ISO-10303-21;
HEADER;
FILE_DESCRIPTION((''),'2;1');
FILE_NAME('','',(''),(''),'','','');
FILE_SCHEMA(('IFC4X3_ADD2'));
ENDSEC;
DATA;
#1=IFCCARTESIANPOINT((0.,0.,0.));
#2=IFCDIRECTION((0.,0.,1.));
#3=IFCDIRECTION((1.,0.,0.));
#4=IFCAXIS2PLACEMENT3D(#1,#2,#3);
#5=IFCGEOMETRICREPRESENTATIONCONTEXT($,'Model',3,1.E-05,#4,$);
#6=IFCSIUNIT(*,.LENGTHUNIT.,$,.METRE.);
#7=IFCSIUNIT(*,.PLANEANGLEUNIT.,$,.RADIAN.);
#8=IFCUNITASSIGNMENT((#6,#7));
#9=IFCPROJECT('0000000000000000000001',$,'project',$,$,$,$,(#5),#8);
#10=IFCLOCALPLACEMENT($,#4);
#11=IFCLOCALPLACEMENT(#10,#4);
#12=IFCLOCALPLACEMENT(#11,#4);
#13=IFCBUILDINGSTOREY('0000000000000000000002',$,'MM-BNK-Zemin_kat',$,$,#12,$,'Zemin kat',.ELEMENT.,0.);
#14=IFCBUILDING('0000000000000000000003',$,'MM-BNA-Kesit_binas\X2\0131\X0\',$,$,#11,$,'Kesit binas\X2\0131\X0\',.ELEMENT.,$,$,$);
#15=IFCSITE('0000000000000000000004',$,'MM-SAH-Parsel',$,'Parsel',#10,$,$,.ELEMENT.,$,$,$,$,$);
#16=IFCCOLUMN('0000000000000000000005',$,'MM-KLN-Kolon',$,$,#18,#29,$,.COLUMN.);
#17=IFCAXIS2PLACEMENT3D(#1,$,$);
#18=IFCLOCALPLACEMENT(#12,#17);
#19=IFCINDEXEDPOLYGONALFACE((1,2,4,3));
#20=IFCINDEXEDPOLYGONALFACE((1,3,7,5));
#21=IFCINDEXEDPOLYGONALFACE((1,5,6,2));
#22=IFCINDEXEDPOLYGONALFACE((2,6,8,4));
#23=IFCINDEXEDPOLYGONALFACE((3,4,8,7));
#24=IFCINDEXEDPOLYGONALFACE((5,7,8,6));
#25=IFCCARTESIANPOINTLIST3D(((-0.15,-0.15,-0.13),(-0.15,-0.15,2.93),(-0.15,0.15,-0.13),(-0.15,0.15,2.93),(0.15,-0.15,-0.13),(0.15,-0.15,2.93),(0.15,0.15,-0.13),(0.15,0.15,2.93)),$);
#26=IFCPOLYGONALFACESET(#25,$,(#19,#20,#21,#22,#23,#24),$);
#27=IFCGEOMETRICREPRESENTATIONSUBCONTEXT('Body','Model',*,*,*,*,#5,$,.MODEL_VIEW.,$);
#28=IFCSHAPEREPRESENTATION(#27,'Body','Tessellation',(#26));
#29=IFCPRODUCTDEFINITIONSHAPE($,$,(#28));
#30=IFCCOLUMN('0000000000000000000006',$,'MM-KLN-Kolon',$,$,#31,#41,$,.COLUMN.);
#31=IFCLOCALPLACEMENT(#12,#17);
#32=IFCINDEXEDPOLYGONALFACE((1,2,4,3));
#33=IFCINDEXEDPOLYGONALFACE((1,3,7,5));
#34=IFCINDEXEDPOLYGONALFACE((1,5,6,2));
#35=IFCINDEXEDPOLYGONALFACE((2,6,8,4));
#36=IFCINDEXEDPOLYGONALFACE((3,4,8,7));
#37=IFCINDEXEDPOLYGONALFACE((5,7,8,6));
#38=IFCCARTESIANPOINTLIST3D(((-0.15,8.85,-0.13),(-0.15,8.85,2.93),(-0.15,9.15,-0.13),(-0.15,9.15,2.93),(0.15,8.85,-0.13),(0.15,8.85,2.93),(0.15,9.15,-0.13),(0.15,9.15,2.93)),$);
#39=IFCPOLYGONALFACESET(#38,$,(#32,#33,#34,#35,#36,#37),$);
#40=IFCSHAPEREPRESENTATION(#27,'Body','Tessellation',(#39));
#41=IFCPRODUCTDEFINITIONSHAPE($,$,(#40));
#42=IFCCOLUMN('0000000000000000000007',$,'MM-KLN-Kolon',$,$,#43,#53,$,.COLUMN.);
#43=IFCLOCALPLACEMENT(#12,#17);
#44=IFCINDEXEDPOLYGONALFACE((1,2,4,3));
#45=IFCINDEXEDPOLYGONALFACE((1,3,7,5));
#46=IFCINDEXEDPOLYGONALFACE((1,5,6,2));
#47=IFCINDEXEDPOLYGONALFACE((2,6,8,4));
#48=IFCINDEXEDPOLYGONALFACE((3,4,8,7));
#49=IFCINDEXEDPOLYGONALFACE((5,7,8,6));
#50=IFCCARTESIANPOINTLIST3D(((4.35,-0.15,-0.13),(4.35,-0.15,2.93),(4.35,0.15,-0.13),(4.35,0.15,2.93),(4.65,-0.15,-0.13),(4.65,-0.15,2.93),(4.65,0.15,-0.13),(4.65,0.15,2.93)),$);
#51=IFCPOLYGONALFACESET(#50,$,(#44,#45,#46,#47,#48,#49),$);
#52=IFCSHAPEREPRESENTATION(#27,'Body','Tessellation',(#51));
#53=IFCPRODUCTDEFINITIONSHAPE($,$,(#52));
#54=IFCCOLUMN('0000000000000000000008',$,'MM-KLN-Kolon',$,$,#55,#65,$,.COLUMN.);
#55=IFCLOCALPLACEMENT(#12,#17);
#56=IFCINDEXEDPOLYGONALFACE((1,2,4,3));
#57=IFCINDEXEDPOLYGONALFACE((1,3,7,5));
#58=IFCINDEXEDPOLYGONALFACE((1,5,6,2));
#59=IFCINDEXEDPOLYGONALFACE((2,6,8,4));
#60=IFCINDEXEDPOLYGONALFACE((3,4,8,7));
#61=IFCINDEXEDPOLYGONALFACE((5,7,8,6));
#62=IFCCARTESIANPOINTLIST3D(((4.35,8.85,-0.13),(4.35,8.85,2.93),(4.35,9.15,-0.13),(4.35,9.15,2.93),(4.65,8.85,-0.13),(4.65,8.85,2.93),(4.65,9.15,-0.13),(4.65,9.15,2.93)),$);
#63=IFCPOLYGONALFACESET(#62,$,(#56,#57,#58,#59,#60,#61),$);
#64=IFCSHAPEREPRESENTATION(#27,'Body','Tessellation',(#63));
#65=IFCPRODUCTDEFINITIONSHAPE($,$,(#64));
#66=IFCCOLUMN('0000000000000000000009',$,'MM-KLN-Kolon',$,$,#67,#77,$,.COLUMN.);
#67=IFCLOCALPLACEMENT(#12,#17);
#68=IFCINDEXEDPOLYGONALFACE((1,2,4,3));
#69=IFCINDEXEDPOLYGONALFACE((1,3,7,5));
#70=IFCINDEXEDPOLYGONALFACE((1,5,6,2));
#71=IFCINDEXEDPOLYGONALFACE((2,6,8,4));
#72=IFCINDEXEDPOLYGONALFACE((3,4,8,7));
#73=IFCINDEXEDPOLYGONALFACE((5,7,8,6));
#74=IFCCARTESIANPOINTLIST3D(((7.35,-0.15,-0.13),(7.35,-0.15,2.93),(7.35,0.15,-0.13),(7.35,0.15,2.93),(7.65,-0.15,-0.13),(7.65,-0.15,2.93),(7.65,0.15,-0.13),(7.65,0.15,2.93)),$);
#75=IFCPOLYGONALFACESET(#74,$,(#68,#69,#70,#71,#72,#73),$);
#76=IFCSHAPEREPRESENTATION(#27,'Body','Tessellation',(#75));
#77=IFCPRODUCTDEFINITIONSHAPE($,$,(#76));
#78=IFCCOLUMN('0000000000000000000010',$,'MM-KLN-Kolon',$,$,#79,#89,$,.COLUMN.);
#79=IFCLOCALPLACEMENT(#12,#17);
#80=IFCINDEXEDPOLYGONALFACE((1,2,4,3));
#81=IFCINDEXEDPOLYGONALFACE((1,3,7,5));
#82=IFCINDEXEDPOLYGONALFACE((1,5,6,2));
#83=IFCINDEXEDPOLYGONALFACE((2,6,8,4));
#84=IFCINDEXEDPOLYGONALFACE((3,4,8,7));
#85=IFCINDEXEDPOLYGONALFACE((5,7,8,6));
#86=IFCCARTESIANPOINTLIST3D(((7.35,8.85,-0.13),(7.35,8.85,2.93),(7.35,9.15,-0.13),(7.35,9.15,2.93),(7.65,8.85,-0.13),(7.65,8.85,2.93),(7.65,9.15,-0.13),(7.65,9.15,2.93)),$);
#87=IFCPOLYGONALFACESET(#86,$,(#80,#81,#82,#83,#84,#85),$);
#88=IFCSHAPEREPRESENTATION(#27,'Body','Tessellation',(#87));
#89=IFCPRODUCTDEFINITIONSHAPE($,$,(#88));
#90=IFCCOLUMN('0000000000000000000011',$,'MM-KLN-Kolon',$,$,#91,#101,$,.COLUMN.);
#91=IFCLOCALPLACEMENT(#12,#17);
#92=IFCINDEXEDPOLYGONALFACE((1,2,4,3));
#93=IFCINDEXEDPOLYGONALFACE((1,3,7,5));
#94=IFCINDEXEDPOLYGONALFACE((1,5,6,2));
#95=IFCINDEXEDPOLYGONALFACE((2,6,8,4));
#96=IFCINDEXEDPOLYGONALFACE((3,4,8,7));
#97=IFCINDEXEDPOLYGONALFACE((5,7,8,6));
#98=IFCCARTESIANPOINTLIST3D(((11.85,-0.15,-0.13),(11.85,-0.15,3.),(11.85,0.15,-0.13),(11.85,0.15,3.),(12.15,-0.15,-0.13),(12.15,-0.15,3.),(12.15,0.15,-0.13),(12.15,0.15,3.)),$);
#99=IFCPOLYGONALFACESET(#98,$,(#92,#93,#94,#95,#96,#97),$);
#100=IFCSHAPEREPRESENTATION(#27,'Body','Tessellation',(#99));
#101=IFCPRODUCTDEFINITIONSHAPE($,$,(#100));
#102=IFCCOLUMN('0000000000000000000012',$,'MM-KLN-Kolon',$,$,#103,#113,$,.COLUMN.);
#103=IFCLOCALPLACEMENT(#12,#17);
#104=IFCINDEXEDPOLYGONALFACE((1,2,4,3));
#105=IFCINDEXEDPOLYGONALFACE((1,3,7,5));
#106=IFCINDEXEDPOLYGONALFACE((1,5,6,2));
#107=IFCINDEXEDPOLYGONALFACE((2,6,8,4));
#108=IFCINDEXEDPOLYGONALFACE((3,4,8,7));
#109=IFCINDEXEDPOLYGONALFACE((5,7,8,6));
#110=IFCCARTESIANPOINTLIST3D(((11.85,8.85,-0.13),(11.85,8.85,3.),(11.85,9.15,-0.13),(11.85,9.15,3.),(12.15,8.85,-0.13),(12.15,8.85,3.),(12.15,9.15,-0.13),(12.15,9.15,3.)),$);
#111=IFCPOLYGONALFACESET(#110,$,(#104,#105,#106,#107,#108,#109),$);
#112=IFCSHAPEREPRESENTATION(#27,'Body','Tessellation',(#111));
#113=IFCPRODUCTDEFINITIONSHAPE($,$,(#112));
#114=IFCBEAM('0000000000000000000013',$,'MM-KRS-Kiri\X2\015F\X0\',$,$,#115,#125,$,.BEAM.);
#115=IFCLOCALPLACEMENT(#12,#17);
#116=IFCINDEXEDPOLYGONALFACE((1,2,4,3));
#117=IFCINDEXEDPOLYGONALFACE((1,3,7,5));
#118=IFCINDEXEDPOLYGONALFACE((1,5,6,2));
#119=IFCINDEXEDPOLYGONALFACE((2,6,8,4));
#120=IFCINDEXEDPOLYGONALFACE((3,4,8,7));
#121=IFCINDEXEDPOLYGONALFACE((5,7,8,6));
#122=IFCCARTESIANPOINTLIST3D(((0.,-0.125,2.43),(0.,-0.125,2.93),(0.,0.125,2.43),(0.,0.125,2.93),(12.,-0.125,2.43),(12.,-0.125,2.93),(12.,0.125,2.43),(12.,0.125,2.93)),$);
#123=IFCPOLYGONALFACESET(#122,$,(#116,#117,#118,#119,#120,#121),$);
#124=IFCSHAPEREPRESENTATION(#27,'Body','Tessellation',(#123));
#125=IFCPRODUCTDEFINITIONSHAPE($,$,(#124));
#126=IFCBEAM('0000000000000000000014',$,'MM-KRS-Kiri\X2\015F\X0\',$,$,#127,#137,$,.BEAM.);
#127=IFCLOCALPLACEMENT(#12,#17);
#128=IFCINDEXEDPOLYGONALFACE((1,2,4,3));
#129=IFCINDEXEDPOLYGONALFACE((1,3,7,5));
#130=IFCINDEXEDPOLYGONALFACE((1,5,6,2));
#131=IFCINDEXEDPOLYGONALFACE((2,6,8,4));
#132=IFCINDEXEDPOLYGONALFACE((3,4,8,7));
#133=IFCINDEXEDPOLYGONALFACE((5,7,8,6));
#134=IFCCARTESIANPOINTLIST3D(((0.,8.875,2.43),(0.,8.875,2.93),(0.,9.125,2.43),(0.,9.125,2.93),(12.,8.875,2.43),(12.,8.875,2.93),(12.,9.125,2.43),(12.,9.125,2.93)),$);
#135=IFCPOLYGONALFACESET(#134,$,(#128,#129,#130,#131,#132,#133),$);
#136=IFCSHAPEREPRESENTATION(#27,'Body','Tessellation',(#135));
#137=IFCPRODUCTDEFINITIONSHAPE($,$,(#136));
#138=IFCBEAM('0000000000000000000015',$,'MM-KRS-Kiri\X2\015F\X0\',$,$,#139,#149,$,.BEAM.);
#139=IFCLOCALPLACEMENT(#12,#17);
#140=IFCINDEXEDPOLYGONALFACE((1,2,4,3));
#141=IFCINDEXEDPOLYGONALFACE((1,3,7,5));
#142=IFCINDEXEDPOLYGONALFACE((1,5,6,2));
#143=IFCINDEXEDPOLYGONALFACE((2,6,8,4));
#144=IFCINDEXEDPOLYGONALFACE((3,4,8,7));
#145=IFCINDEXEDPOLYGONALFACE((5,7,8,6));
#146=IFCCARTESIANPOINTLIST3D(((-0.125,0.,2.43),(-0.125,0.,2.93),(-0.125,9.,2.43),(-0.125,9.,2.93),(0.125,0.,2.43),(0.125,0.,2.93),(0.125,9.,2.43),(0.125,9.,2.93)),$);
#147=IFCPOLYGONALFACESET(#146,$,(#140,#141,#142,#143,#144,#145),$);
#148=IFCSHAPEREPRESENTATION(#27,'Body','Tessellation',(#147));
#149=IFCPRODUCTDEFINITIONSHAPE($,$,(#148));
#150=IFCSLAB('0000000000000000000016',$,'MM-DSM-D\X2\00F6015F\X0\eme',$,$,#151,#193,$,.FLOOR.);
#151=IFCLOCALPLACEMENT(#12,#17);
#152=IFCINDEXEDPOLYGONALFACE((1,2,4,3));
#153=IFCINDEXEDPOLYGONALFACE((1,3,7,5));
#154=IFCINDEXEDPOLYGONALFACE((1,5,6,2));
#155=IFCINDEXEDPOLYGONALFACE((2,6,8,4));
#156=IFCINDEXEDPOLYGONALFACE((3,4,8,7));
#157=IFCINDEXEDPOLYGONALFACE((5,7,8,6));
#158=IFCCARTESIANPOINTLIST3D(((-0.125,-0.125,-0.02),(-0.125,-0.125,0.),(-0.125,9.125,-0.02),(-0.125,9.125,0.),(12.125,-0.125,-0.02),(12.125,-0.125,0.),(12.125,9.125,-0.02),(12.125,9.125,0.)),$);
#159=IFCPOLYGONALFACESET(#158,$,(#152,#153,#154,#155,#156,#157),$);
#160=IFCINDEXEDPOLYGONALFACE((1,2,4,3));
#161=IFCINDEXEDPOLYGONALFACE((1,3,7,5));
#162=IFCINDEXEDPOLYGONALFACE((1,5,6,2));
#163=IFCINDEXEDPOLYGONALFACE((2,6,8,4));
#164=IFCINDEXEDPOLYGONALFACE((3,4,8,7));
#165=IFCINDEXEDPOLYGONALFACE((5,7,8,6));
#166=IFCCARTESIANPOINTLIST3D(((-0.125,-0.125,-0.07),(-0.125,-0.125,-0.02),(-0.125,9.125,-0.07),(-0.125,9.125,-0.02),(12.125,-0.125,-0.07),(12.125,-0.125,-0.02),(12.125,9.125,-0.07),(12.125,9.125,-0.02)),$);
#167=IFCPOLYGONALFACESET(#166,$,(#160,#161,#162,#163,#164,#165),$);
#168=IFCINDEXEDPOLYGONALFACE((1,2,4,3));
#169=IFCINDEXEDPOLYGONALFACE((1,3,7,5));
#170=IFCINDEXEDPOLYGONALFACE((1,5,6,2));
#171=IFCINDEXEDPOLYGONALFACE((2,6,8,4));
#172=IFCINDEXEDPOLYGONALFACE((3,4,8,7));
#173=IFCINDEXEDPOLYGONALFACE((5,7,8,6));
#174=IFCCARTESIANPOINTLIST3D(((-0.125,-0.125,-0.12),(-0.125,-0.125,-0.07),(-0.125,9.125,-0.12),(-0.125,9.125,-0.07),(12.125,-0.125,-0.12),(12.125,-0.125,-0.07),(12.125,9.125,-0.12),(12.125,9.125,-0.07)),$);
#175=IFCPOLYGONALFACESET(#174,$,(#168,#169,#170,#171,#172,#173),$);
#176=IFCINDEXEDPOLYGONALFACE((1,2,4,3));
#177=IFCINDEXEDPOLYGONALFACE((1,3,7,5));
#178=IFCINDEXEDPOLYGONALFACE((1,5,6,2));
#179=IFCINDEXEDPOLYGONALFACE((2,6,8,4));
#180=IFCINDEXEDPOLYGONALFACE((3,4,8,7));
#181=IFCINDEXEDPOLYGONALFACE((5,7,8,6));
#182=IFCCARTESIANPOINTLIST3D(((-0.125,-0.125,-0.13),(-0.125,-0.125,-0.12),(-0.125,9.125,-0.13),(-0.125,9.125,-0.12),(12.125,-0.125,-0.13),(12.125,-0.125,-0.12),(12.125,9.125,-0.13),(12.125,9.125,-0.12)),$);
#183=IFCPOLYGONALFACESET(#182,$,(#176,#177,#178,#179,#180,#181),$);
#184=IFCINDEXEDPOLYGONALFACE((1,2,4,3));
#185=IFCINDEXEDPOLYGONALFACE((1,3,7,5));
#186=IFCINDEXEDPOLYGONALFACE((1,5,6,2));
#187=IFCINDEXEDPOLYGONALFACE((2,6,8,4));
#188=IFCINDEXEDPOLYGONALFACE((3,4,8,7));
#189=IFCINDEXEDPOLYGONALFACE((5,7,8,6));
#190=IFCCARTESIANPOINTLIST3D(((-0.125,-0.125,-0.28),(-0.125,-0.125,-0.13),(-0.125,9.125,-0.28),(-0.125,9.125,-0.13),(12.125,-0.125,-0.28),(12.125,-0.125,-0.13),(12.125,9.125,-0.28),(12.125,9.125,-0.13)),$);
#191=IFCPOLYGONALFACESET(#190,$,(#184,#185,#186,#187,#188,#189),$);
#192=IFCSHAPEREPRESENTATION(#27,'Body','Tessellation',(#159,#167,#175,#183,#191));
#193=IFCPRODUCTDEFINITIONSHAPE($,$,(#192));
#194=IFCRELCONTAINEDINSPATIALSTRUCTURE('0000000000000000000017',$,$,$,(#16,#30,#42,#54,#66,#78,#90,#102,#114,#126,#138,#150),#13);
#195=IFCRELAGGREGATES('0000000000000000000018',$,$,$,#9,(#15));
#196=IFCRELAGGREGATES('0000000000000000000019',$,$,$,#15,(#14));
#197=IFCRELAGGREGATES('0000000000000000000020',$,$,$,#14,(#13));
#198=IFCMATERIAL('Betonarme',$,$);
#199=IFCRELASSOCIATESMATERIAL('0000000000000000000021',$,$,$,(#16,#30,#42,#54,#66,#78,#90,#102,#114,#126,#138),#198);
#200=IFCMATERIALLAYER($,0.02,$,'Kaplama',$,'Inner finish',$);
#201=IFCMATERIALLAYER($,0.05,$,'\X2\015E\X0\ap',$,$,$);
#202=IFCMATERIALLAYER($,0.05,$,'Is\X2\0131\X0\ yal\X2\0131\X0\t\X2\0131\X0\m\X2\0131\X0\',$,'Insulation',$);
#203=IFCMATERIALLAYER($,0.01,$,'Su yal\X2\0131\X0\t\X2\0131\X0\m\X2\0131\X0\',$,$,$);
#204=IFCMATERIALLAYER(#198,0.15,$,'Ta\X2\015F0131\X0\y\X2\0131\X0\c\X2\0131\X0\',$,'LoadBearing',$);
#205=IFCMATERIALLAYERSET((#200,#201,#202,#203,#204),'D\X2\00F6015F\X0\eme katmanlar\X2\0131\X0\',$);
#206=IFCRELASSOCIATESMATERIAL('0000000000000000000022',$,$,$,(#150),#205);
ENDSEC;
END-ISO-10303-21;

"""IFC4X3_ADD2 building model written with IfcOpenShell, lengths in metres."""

from ifc_helpers import new_model, si_unit, frame, origin_with_axes, place, context, subcontext, project, spatial, polyline, outline, extrude, material, layer, layer_set, layer_usage, element, save


model = new_model("IFC4X3_ADD2")

# Units and contexts
model_context = context("Model", 3, precision=1e-05, world=origin_with_axes())
body_context = subcontext(model_context, "Body", "Model", "MODEL_VIEW")
ifc_project = project(units=[si_unit("LENGTHUNIT", "METRE"), si_unit("PLANEANGLEUNIT", "RADIAN")], contexts=[model_context])

# Site, building, storey
site_placement = place(None, origin_with_axes())
site = spatial("IfcSite", under=ifc_project, at=site_placement, Name="MM-SAH-Parsel", ObjectType="Parsel", CompositionType="ELEMENT")
building_placement = place(site_placement, origin_with_axes())
building = spatial("IfcBuilding", under=site, at=building_placement, Name="MM-BNA-Kesit_binası", LongName="Kesit binası", CompositionType="ELEMENT")
storey_placement = place(building_placement, origin_with_axes())
storey = spatial("IfcBuildingStorey", under=building, at=storey_placement, Name="MM-BNK-Zemin_kat", LongName="Zemin kat", CompositionType="ELEMENT", Elevation=0.0)

# Columns
ifc_material_1 = material(Name="Betonarme")
column_1_placement = place(storey_placement, origin_with_axes())
element("IfcColumn", 1, at=column_1_placement, inside=storey, material=ifc_material_1, Name="MM-KLN-Kolon", PredefinedType="COLUMN", context=body_context, shape_type="SweptSolid", body=[
    extrude(outline(polyline([(-0.15, -0.15), (0.15, -0.15), (0.15, 0.15), (-0.15, 0.15), (-0.15, -0.15)])), frame((0.0, 0.0, -0.13)), (0.0, 0.0, 1.0), 3.06),
])
column_2_placement = place(storey_placement, origin_with_axes())
element("IfcColumn", 2, at=column_2_placement, inside=storey, material=ifc_material_1, Name="MM-KLN-Kolon", PredefinedType="COLUMN", context=body_context, shape_type="SweptSolid", body=[
    extrude(outline(polyline([(-0.15, 8.85), (0.15, 8.85), (0.15, 9.15), (-0.15, 9.15), (-0.15, 8.85)])), frame((0.0, 0.0, -0.13)), (0.0, 0.0, 1.0), 3.06),
])
column_3_placement = place(storey_placement, origin_with_axes())
element("IfcColumn", 3, at=column_3_placement, inside=storey, material=ifc_material_1, Name="MM-KLN-Kolon", PredefinedType="COLUMN", context=body_context, shape_type="SweptSolid", body=[
    extrude(outline(polyline([(4.35, -0.15), (4.65, -0.15), (4.65, 0.15), (4.35, 0.15), (4.35, -0.15)])), frame((0.0, 0.0, -0.13)), (0.0, 0.0, 1.0), 3.06),
])
column_4_placement = place(storey_placement, origin_with_axes())
element("IfcColumn", 4, at=column_4_placement, inside=storey, material=ifc_material_1, Name="MM-KLN-Kolon", PredefinedType="COLUMN", context=body_context, shape_type="SweptSolid", body=[
    extrude(outline(polyline([(4.35, 8.85), (4.65, 8.85), (4.65, 9.15), (4.35, 9.15), (4.35, 8.85)])), frame((0.0, 0.0, -0.13)), (0.0, 0.0, 1.0), 3.06),
])
column_5_placement = place(storey_placement, origin_with_axes())
element("IfcColumn", 5, at=column_5_placement, inside=storey, material=ifc_material_1, Name="MM-KLN-Kolon", PredefinedType="COLUMN", context=body_context, shape_type="SweptSolid", body=[
    extrude(outline(polyline([(7.35, -0.15), (7.65, -0.15), (7.65, 0.15), (7.35, 0.15), (7.35, -0.15)])), frame((0.0, 0.0, -0.13)), (0.0, 0.0, 1.0), 3.06),
])
column_6_placement = place(storey_placement, origin_with_axes())
element("IfcColumn", 6, at=column_6_placement, inside=storey, material=ifc_material_1, Name="MM-KLN-Kolon", PredefinedType="COLUMN", context=body_context, shape_type="SweptSolid", body=[
    extrude(outline(polyline([(7.35, 8.85), (7.65, 8.85), (7.65, 9.15), (7.35, 9.15), (7.35, 8.85)])), frame((0.0, 0.0, -0.13)), (0.0, 0.0, 1.0), 3.06),
])
column_7_placement = place(storey_placement, origin_with_axes())
element("IfcColumn", 7, at=column_7_placement, inside=storey, material=ifc_material_1, Name="MM-KLN-Kolon", PredefinedType="COLUMN", context=body_context, shape_type="SweptSolid", body=[
    extrude(outline(polyline([(11.85, -0.15), (12.15, -0.15), (12.15, 0.15), (11.85, 0.15), (11.85, -0.15)])), frame((0.0, 0.0, -0.13)), (0.0, 0.0, 1.0), 3.13),
])
column_8_placement = place(storey_placement, origin_with_axes())
element("IfcColumn", 8, at=column_8_placement, inside=storey, material=ifc_material_1, Name="MM-KLN-Kolon", PredefinedType="COLUMN", context=body_context, shape_type="SweptSolid", body=[
    extrude(outline(polyline([(11.85, 8.85), (12.15, 8.85), (12.15, 9.15), (11.85, 9.15), (11.85, 8.85)])), frame((0.0, 0.0, -0.13)), (0.0, 0.0, 1.0), 3.13),
])

# Beams
beam_1_placement = place(storey_placement, origin_with_axes())
element("IfcBeam", 9, at=beam_1_placement, inside=storey, material=ifc_material_1, Name="MM-KRS-Kiriş", PredefinedType="BEAM", context=body_context, shape_type="SweptSolid", body=[
    extrude(outline(polyline([(0.0, 0.125), (12.0, 0.125), (12.0, -0.125), (0.0, -0.125), (0.0, 0.125)])), frame((0.0, 0.0, 2.43)), (0.0, 0.0, 1.0), 0.5),
])
beam_2_placement = place(storey_placement, origin_with_axes())
element("IfcBeam", 10, at=beam_2_placement, inside=storey, material=ifc_material_1, Name="MM-KRS-Kiriş", PredefinedType="BEAM", context=body_context, shape_type="SweptSolid", body=[
    extrude(outline(polyline([(12.0, 8.875), (0.0, 8.875), (0.0, 9.125), (12.0, 9.125), (12.0, 8.875)])), frame((0.0, 0.0, 2.43)), (0.0, 0.0, 1.0), 0.5),
])
beam_3_placement = place(storey_placement, origin_with_axes())
element("IfcBeam", 11, at=beam_3_placement, inside=storey, material=ifc_material_1, Name="MM-KRS-Kiriş", PredefinedType="BEAM", context=body_context, shape_type="SweptSolid", body=[
    extrude(outline(polyline([(0.125, 9.0), (0.125, 0.0), (-0.125, 0.0), (-0.125, 9.0), (0.125, 9.0)])), frame((0.0, 0.0, 2.43)), (0.0, 0.0, 1.0), 0.5),
])

# Slab
ifc_layer_1 = layer(None, 0.02, Name="Kaplama", Category="Inner finish")
ifc_layer_2 = layer(None, 0.05, Name="Şap")
ifc_layer_3 = layer(None, 0.05, Name="Isı yalıtımı", Category="Insulation")
ifc_layer_4 = layer(None, 0.01, Name="Su yalıtımı")
ifc_layer_5 = layer(ifc_material_1, 0.15, Name="Taşıyıcı", Category="LoadBearing")
ifc_layer_set_1 = layer_set([ifc_layer_1, ifc_layer_2, ifc_layer_3, ifc_layer_4, ifc_layer_5], Name="Döşeme katmanları")
ifc_layer_usage = layer_usage(ifc_layer_set_1, "AXIS3", "NEGATIVE", 0.0)
slab_placement = place(storey_placement, origin_with_axes())
element("IfcSlab", 12, at=slab_placement, inside=storey, material=ifc_layer_usage, Name="MM-DSM-Döşeme", PredefinedType="FLOOR", context=body_context, shape_type="SweptSolid", body=[
    extrude(outline(polyline([(-0.125, -0.125), (12.125, -0.125), (12.125, 9.125), (-0.125, 9.125), (-0.125, -0.125)])), frame((0.0, 0.0, -0.02)), (0.0, 0.0, 1.0), 0.02),
    extrude(outline(polyline([(-0.125, -0.125), (12.125, -0.125), (12.125, 9.125), (-0.125, 9.125), (-0.125, -0.125)])), frame((0.0, 0.0, -0.07)), (0.0, 0.0, 1.0), 0.05),
    extrude(outline(polyline([(-0.125, -0.125), (12.125, -0.125), (12.125, 9.125), (-0.125, 9.125), (-0.125, -0.125)])), frame((0.0, 0.0, -0.12)), (0.0, 0.0, 1.0), 0.05),
    extrude(outline(polyline([(-0.125, -0.125), (12.125, -0.125), (12.125, 9.125), (-0.125, 9.125), (-0.125, -0.125)])), frame((0.0, 0.0, -0.13)), (0.0, 0.0, 1.0), 0.01),
    extrude(outline(polyline([(-0.125, -0.125), (12.125, -0.125), (12.125, 9.125), (-0.125, 9.125), (-0.125, -0.125)])), frame((0.0, 0.0, -0.28)), (0.0, 0.0, 1.0), 0.15),
])

save(model, "model.ifc")
